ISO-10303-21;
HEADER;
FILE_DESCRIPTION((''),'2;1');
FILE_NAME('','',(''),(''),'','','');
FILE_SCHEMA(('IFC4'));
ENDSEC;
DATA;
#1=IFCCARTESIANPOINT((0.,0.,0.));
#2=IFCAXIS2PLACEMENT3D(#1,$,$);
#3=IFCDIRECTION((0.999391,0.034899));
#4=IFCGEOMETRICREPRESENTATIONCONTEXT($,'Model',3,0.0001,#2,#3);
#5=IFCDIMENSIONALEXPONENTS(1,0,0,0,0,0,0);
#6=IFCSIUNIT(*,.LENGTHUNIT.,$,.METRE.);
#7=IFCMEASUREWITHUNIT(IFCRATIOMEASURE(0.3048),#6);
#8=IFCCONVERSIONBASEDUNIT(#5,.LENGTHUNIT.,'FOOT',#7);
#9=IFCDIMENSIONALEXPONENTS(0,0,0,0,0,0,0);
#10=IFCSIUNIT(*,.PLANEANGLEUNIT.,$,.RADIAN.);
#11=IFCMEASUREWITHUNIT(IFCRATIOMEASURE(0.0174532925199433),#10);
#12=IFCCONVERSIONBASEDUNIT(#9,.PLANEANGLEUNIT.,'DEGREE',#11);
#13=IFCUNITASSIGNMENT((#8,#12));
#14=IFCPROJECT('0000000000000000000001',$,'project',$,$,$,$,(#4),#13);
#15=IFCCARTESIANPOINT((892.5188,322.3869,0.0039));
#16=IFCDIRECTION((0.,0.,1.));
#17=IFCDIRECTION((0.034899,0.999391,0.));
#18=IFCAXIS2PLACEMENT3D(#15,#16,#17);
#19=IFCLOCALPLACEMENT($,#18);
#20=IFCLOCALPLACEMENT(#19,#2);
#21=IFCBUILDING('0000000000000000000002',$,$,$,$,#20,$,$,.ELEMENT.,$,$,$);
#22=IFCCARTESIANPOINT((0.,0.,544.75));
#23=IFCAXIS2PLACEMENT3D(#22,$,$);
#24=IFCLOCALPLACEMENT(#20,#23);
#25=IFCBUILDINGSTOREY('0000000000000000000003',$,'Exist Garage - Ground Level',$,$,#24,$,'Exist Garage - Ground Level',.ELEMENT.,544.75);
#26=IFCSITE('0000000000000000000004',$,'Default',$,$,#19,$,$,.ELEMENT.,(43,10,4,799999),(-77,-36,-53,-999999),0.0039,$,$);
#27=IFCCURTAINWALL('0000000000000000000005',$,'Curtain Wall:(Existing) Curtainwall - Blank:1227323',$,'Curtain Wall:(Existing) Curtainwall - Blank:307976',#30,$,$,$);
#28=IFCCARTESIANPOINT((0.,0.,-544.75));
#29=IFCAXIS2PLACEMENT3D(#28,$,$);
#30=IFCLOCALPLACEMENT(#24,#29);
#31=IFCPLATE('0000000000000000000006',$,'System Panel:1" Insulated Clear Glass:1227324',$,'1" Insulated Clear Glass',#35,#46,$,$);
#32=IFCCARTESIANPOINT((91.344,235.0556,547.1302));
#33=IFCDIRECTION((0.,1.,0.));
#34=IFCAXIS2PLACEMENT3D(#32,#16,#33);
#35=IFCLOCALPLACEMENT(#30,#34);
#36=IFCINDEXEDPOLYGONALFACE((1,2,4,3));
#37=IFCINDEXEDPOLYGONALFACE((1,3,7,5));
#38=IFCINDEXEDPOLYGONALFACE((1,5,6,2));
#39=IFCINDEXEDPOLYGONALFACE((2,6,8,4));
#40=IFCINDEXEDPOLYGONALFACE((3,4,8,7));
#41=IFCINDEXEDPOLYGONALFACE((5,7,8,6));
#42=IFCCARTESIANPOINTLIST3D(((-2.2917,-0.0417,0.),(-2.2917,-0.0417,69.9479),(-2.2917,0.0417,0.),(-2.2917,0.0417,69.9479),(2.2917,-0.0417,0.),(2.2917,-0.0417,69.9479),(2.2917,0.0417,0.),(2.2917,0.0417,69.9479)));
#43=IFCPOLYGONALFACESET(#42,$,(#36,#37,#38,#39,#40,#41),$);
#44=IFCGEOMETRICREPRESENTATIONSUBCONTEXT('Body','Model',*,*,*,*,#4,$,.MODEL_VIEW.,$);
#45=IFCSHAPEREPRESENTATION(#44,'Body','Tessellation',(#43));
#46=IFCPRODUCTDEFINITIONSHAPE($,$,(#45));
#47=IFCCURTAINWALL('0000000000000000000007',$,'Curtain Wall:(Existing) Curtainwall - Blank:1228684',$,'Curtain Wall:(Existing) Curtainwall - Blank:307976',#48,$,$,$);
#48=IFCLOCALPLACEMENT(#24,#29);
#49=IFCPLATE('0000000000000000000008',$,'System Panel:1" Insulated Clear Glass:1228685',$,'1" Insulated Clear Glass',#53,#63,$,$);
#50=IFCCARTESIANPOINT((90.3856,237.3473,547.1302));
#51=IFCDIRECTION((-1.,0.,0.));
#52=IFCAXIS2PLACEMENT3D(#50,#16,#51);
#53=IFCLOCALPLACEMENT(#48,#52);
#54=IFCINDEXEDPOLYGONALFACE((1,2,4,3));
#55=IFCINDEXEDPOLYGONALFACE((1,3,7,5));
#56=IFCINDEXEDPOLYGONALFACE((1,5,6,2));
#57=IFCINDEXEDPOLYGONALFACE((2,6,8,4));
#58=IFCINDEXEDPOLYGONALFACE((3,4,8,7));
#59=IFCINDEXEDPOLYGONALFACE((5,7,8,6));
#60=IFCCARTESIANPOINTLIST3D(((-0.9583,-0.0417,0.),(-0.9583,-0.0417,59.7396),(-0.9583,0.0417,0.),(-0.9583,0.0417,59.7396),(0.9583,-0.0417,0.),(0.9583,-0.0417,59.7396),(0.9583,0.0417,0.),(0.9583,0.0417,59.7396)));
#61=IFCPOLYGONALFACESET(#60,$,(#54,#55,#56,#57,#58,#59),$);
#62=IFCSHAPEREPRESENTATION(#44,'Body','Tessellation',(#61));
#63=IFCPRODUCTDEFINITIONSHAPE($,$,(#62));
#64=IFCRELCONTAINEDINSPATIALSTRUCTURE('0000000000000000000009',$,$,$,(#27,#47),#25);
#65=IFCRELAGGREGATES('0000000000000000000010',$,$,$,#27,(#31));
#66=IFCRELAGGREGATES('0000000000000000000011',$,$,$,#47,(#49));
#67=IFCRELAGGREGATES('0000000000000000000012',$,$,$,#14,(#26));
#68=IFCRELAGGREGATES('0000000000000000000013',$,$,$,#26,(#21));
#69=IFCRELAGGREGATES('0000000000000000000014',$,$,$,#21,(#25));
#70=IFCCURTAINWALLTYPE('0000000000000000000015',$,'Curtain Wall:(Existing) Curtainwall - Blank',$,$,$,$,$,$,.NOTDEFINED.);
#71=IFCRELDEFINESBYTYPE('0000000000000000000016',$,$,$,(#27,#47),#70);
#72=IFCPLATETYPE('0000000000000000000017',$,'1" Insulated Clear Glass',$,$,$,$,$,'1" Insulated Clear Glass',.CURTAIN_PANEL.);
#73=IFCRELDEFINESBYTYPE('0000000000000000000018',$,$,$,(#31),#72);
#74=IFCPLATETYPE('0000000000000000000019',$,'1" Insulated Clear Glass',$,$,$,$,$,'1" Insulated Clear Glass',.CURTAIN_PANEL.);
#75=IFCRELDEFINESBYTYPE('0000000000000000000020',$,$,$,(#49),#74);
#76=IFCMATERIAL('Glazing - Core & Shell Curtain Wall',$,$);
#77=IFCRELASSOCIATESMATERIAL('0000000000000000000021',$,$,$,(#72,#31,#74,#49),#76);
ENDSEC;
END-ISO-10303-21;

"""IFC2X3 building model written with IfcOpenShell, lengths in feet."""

from ifc_helpers import new_model, entity, si_unit, converted_unit, direction, frame, origin, origin_2d_with_axis, place, context, subcontext, project, spatial, rectangle, extrude, source, transform, mapped, material, type_object, type_shapes, element, aggregate, save


model = new_model("IFC2X3")

# Units and contexts
model_context = context("Model", 3, precision=0.0001, world=origin(), true_north=direction((0.999391, 0.034899)))
body_context = subcontext(model_context, "Body", "Model", "MODEL_VIEW")
ifc_project = project(units=[converted_unit("LENGTHUNIT", "FOOT", entity("IfcRatioMeasure", 0.3048), si_unit("LENGTHUNIT", "METRE"), dimensions=[1, 0, 0, 0, 0, 0, 0]), converted_unit("PLANEANGLEUNIT", "DEGREE", entity("IfcRatioMeasure", 0.0174532925199433), si_unit("PLANEANGLEUNIT", "RADIAN"), dimensions=[0, 0, 0, 0, 0, 0, 0])], contexts=[model_context])

# Site, building, storey
site_placement = place(None, frame((892.5188, 322.3869, 0.0039), z_axis=(0.0, 0.0, 1.0), x_axis=(0.034899, 0.999391, 0.0)))
site = spatial("IfcSite", under=ifc_project, at=site_placement, Name="Default", CompositionType="ELEMENT", RefLatitude=(43, 10, 4, 799999), RefLongitude=(-77, -36, -53, -999999), RefElevation=0.0039)
building_placement = place(site_placement, origin())
building = spatial("IfcBuilding", under=site, at=building_placement, CompositionType="ELEMENT")
storey_placement = place(building_placement, frame((0.0, 0.0, 544.75)))
storey = spatial("IfcBuildingStorey", under=building, at=storey_placement, Name="Exist Garage - Ground Level", LongName="Exist Garage - Ground Level", CompositionType="ELEMENT", Elevation=544.75)

# Shared definitions
curtain_wall_type = type_object("IfcCurtainWallType", Name="Curtain Wall:(Existing) Curtainwall - Blank", PredefinedType="NOTDEFINED")
ifc_material_1 = material(Name="Glazing - Core & Shell Curtain Wall")

# Curtain walls, plates
curtain_wall_1_placement = place(storey_placement, frame((0.0, 0.0, -544.75)))
curtain_wall_1 = element("IfcCurtainWall", 1, at=curtain_wall_1_placement, inside=storey, type_object=curtain_wall_type, Name="Curtain Wall:(Existing) Curtainwall - Blank:1227323", ObjectType="Curtain Wall:(Existing) Curtainwall - Blank:307976")
plate_type_1 = type_object("IfcPlateType", Name="1\" Insulated Clear Glass", ElementType="1\" Insulated Clear Glass", PredefinedType="CURTAIN_PANEL", material=ifc_material_1)
shared_shape_1 = source(origin(), body_context, "Body", "SweptSolid", [
    extrude(rectangle(XDim=0.0833, YDim=4.5833, at=origin_2d_with_axis()), frame((0.0, 0.0, 0.0), z_axis=(0.0, 0.0, 1.0), x_axis=(0.0, 1.0, 0.0)), (0.0, 0.0, 1.0), 69.9479),
])
type_shapes(plate_type_1, [shared_shape_1])
plate_1_placement = place(curtain_wall_1_placement, frame((91.344, 235.0556, 547.1302), z_axis=(0.0, 0.0, 1.0), x_axis=(0.0, 1.0, 0.0)))
plate_1 = element("IfcPlate", 2, at=plate_1_placement, type_object=plate_type_1, material=ifc_material_1, Name="System Panel:1\" Insulated Clear Glass:1227324", ObjectType="1\" Insulated Clear Glass", context=body_context, shape_type="MappedRepresentation", body=[
    mapped(shared_shape_1, transform((0.0, 0.0, 0.0), scale=1.0)),
])
aggregate(curtain_wall_1, [plate_1])
curtain_wall_2_placement = place(storey_placement, frame((0.0, 0.0, -544.75)))
curtain_wall_2 = element("IfcCurtainWall", 3, at=curtain_wall_2_placement, inside=storey, type_object=curtain_wall_type, Name="Curtain Wall:(Existing) Curtainwall - Blank:1228684", ObjectType="Curtain Wall:(Existing) Curtainwall - Blank:307976")
plate_type_2 = type_object("IfcPlateType", Name="1\" Insulated Clear Glass", ElementType="1\" Insulated Clear Glass", PredefinedType="CURTAIN_PANEL", material=ifc_material_1)
shared_shape_2 = source(origin(), body_context, "Body", "SweptSolid", [
    extrude(rectangle(XDim=0.0833, YDim=1.9167, at=origin_2d_with_axis()), frame((0.0, 0.0, 0.0), z_axis=(0.0, 0.0, 1.0), x_axis=(0.0, 1.0, 0.0)), (0.0, 0.0, 1.0), 59.7396),
])
type_shapes(plate_type_2, [shared_shape_2])
plate_2_placement = place(curtain_wall_2_placement, frame((90.3856, 237.3473, 547.1302), z_axis=(0.0, 0.0, 1.0), x_axis=(-1.0, 0.0, 0.0)))
plate_2 = element("IfcPlate", 4, at=plate_2_placement, type_object=plate_type_2, material=ifc_material_1, Name="System Panel:1\" Insulated Clear Glass:1228685", ObjectType="1\" Insulated Clear Glass", context=body_context, shape_type="MappedRepresentation", body=[
    mapped(shared_shape_2, transform((0.0, 0.0, 0.0), scale=1.0)),
])
aggregate(curtain_wall_2, [plate_2])

save(model, "model.ifc")
